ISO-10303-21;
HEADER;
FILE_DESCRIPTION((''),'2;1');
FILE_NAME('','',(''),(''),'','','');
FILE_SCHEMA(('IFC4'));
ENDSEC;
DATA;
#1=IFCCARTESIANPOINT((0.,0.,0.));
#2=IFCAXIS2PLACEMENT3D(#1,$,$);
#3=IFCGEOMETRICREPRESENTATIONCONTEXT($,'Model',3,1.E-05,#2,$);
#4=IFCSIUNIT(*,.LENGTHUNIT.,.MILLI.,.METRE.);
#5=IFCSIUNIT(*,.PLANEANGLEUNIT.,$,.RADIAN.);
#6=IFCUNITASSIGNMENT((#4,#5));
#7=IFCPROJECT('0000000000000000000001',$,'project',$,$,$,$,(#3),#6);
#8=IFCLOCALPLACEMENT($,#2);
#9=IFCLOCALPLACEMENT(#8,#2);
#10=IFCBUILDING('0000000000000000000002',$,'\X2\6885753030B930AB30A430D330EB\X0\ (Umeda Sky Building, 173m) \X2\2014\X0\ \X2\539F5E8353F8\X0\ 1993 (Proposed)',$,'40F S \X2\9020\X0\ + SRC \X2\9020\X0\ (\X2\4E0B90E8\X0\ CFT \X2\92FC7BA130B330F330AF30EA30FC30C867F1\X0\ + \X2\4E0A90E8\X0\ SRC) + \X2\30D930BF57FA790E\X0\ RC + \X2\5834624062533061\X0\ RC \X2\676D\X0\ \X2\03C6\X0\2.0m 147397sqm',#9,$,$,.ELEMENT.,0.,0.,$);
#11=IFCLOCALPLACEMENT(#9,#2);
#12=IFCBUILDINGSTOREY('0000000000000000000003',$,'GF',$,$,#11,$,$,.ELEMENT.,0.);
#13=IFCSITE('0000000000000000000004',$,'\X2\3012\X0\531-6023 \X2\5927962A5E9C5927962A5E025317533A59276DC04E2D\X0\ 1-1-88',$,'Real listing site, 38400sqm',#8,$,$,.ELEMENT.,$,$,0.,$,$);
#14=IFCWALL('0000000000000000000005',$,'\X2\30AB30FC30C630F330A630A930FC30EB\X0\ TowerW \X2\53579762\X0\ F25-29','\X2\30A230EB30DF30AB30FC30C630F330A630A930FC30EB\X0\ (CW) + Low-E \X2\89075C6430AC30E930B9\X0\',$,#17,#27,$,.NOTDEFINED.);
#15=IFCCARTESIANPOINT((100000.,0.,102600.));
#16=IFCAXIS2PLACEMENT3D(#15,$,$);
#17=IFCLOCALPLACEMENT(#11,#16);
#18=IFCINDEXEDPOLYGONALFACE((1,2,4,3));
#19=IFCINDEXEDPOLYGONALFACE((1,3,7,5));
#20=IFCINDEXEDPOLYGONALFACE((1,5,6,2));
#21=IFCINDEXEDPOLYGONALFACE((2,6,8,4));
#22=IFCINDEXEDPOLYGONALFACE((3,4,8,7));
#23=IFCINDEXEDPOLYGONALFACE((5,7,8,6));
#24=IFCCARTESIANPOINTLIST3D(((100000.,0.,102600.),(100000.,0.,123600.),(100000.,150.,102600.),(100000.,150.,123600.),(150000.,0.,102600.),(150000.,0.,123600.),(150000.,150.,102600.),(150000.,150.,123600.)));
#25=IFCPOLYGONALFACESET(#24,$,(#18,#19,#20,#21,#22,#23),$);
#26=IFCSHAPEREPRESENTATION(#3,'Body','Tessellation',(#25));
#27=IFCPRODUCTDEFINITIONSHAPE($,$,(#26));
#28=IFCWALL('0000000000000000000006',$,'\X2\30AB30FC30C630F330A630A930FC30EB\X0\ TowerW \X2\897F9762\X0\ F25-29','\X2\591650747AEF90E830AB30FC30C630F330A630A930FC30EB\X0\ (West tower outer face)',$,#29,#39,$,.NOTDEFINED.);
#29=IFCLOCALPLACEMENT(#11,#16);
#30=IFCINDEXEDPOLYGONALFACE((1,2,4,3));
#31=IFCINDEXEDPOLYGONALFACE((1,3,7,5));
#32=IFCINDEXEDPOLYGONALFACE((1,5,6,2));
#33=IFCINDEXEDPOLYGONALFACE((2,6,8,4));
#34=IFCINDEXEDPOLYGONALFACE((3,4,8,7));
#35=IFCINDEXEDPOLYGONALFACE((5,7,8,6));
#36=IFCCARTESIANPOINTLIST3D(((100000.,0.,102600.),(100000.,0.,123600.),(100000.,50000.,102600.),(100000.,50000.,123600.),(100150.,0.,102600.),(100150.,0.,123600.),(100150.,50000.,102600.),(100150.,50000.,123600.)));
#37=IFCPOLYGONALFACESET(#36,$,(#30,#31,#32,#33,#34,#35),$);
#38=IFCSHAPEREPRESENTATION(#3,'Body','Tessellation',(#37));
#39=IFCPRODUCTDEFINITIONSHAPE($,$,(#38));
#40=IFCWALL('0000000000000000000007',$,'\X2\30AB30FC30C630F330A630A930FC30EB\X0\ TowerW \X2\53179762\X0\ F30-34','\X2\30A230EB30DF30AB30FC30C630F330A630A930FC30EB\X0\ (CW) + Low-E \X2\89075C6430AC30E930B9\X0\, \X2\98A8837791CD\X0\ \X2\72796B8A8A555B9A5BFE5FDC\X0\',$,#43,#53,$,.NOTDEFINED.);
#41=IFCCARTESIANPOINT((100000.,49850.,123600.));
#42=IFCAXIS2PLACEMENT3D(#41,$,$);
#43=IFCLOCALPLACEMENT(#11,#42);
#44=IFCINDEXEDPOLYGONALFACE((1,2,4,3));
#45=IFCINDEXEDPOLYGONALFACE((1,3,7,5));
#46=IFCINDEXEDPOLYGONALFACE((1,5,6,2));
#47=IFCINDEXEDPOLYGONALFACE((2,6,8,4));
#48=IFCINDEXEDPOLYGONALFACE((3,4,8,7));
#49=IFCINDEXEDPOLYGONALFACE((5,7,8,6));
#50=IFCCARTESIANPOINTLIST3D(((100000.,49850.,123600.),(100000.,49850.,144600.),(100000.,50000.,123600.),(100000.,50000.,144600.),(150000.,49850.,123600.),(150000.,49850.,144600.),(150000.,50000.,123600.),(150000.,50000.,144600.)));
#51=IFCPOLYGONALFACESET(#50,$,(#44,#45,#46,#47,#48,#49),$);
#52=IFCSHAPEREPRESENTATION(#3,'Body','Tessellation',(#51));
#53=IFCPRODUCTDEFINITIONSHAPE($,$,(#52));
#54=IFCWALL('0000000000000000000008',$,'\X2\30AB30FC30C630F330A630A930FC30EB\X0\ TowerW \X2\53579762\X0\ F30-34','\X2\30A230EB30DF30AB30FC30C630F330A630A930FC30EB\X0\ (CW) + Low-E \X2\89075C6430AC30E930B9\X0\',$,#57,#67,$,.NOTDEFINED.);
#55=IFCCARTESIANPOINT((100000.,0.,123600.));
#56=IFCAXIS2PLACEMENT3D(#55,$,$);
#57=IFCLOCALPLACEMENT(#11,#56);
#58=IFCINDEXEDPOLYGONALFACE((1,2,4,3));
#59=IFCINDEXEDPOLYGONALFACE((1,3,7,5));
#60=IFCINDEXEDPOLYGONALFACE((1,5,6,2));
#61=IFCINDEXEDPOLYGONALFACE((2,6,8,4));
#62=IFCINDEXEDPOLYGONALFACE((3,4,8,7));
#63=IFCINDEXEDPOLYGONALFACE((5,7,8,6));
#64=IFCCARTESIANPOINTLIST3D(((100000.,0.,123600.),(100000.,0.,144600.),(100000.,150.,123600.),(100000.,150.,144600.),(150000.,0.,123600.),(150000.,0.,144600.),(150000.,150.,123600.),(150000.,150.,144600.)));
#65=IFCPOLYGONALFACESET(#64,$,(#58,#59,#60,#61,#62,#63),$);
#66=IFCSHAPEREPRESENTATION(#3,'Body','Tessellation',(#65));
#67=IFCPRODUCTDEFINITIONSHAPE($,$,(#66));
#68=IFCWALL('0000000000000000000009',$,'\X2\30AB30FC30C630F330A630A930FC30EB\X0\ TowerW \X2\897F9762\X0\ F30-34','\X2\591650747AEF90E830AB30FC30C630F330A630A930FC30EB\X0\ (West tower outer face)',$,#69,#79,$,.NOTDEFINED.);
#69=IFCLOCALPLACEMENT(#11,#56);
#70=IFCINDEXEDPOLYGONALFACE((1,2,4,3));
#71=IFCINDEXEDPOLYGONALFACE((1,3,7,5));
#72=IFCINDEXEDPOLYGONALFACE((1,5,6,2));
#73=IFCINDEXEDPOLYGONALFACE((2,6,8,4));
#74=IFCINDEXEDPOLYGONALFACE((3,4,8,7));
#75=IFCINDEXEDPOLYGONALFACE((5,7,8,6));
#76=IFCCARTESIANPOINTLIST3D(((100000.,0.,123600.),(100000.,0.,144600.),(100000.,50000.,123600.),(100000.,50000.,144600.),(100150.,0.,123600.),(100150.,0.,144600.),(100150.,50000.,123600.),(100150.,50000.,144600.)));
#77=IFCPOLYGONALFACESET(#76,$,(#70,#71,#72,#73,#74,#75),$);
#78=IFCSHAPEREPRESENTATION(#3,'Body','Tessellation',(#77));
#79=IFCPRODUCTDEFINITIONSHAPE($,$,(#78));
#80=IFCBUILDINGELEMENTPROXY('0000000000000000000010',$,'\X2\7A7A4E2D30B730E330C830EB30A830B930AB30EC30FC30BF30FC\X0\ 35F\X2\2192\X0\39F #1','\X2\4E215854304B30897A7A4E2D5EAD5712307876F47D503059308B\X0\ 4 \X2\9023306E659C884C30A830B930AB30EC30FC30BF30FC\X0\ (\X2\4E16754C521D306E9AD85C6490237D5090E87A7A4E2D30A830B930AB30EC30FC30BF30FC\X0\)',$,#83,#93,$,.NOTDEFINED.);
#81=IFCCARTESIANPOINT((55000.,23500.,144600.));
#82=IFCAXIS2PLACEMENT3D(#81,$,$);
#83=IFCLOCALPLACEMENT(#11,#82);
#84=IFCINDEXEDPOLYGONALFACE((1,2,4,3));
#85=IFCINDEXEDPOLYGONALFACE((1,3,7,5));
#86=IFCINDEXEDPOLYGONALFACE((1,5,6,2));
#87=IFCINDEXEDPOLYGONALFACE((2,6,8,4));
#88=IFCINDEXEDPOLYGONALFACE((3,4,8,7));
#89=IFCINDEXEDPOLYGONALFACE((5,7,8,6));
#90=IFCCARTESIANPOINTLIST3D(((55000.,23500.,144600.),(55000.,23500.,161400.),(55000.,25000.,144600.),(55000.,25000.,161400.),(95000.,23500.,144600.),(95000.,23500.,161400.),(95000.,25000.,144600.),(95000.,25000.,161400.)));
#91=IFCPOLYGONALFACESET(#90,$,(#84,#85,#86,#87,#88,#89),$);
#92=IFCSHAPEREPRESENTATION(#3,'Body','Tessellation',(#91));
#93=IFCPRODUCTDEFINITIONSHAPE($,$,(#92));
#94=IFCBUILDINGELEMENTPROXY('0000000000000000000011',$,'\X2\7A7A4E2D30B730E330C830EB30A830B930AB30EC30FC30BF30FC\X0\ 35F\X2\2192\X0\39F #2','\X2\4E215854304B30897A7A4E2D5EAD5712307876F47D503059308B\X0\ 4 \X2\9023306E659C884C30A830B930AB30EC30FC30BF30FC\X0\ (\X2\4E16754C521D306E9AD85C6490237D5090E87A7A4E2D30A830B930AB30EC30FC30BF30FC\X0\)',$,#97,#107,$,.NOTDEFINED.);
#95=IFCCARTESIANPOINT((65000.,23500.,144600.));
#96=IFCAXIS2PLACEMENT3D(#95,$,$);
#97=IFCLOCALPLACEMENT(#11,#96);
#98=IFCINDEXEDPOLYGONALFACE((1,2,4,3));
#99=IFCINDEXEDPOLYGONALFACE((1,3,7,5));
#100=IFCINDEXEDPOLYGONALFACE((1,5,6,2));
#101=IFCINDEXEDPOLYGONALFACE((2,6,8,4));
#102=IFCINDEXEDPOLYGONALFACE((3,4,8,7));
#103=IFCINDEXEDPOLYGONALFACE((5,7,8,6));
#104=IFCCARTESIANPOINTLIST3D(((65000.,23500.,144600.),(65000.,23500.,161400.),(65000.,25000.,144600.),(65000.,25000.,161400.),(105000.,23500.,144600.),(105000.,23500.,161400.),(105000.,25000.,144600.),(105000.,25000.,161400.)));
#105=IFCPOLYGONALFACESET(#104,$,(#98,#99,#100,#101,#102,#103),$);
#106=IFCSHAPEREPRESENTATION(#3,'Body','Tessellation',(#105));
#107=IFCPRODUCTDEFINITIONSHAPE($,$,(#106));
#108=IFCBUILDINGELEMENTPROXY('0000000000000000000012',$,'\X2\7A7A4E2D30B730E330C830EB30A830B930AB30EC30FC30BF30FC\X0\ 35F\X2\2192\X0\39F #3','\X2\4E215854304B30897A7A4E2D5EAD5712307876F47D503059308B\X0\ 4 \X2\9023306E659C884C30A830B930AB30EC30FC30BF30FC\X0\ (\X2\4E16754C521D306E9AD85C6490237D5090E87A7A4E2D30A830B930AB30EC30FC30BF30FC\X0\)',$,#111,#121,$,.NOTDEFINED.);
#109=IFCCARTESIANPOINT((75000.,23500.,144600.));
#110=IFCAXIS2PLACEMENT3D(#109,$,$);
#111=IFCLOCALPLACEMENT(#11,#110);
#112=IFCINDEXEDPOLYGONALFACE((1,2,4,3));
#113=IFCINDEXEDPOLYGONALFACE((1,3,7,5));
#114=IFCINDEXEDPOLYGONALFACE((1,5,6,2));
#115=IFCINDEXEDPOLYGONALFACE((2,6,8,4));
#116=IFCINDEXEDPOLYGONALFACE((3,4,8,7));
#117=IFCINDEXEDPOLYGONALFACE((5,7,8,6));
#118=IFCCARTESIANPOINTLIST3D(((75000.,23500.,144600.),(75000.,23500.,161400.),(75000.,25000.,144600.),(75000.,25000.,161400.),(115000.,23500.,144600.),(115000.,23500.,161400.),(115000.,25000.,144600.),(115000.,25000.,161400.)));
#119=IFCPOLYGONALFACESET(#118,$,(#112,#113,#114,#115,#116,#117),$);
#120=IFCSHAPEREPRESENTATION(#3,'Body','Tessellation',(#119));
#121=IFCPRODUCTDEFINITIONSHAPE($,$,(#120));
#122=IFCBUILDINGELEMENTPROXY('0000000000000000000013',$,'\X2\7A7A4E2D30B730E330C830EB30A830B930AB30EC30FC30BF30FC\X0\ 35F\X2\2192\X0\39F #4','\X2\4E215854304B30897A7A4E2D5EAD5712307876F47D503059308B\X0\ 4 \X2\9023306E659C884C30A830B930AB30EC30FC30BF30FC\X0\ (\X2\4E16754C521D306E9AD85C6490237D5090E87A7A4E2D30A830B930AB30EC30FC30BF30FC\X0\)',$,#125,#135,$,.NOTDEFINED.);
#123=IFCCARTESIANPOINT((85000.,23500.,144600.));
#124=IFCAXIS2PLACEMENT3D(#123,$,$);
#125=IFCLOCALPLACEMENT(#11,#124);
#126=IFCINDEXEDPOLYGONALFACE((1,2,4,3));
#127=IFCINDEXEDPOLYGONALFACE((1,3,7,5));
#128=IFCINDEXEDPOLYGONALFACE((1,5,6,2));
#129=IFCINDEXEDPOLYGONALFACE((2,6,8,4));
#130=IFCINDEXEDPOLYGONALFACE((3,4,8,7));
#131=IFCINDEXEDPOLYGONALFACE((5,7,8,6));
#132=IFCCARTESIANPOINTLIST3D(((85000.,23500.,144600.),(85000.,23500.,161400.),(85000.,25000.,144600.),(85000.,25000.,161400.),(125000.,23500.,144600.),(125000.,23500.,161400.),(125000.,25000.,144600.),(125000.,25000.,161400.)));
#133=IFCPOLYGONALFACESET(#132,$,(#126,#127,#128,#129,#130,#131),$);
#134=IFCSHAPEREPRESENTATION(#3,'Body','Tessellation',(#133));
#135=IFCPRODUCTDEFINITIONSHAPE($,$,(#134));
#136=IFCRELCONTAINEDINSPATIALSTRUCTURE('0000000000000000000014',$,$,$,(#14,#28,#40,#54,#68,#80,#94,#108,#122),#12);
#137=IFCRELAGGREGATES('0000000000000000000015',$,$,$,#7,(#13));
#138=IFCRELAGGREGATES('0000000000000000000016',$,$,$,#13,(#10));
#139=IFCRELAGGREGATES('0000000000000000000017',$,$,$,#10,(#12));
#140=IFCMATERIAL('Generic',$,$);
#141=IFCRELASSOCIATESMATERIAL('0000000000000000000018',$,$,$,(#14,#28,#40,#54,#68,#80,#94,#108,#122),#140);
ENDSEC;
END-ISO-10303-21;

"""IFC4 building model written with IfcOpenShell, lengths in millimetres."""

from ifc_helpers import new_model, si_unit, frame, frame_2d, origin, place, context, project, spatial, rectangle, extrude, material, element, save


model = new_model("IFC4")

# Units and contexts
model_context = context("Model", 3, precision=1e-05, world=origin())
ifc_project = project(units=[si_unit("LENGTHUNIT", "METRE", prefix="MILLI"), si_unit("PLANEANGLEUNIT", "RADIAN")], contexts=[model_context])

# Site, building, storey
site_placement = place(None, origin())
site = spatial("IfcSite", under=ifc_project, at=site_placement, Name="〒531-6023 大阪府大阪市北区大淀中 1-1-88", ObjectType="Real listing site, 38400sqm", CompositionType="ELEMENT", RefElevation=0.0)
building_placement = place(site_placement, origin())
building = spatial("IfcBuilding", under=site, at=building_placement, Name="梅田スカイビル (Umeda Sky Building, 173m) — 原広司 1993 (Proposed)", ObjectType="40F S 造 + SRC 造 (下部 CFT 鋼管コンクリート柱 + 上部 SRC) + ベタ基礎 RC + 場所打ち RC 杭 φ2.0m 147397sqm", CompositionType="ELEMENT", ElevationOfRefHeight=0.0, ElevationOfTerrain=0.0)
storey_placement = place(building_placement, origin())
storey = spatial("IfcBuildingStorey", under=building, at=storey_placement, Name="GF", CompositionType="ELEMENT", Elevation=0.0)

# Shared definitions
ifc_material_1 = material(Name="Generic")

# Walls
wall_1_placement = place(storey_placement, frame((100000.0, 0.0, 102600.0)))
element("IfcWall", 1, at=wall_1_placement, inside=storey, material=ifc_material_1, Name="カーテンウォール TowerW 南面 F25-29", Description="アルミカーテンウォール (CW) + Low-E 複層ガラス", PredefinedType="NOTDEFINED", context=model_context, shape_type="SweptSolid", body=[
    extrude(rectangle(XDim=50000.0, YDim=150.0, at=frame_2d((25000.0, 75.0))), frame((100000.0, 0.0, 102600.0)), (0.0, 0.0, 1.0), 21000.0),
])
wall_2_placement = place(storey_placement, frame((100000.0, 0.0, 102600.0)))
element("IfcWall", 2, at=wall_2_placement, inside=storey, material=ifc_material_1, Name="カーテンウォール TowerW 西面 F25-29", Description="外側端部カーテンウォール (West tower outer face)", PredefinedType="NOTDEFINED", context=model_context, shape_type="SweptSolid", body=[
    extrude(rectangle(XDim=150.0, YDim=50000.0, at=frame_2d((75.0, 25000.0))), frame((100000.0, 0.0, 102600.0)), (0.0, 0.0, 1.0), 21000.0),
])
wall_3_placement = place(storey_placement, frame((100000.0, 49850.0, 123600.0)))
element("IfcWall", 3, at=wall_3_placement, inside=storey, material=ifc_material_1, Name="カーテンウォール TowerW 北面 F30-34", Description="アルミカーテンウォール (CW) + Low-E 複層ガラス, 風荷重 特殊評定対応", PredefinedType="NOTDEFINED", context=model_context, shape_type="SweptSolid", body=[
    extrude(rectangle(XDim=50000.0, YDim=150.0, at=frame_2d((25000.0, 75.0))), frame((100000.0, 49850.0, 123600.0)), (0.0, 0.0, 1.0), 21000.0),
])
wall_4_placement = place(storey_placement, frame((100000.0, 0.0, 123600.0)))
element("IfcWall", 4, at=wall_4_placement, inside=storey, material=ifc_material_1, Name="カーテンウォール TowerW 南面 F30-34", Description="アルミカーテンウォール (CW) + Low-E 複層ガラス", PredefinedType="NOTDEFINED", context=model_context, shape_type="SweptSolid", body=[
    extrude(rectangle(XDim=50000.0, YDim=150.0, at=frame_2d((25000.0, 75.0))), frame((100000.0, 0.0, 123600.0)), (0.0, 0.0, 1.0), 21000.0),
])
wall_5_placement = place(storey_placement, frame((100000.0, 0.0, 123600.0)))
element("IfcWall", 5, at=wall_5_placement, inside=storey, material=ifc_material_1, Name="カーテンウォール TowerW 西面 F30-34", Description="外側端部カーテンウォール (West tower outer face)", PredefinedType="NOTDEFINED", context=model_context, shape_type="SweptSolid", body=[
    extrude(rectangle(XDim=150.0, YDim=50000.0, at=frame_2d((75.0, 25000.0))), frame((100000.0, 0.0, 123600.0)), (0.0, 0.0, 1.0), 21000.0),
])

# Building element proxies
proxy_1_placement = place(storey_placement, frame((55000.0, 23500.0, 144600.0)))
element("IfcBuildingElementProxy", 6, at=proxy_1_placement, inside=storey, material=ifc_material_1, Name="空中シャトルエスカレーター 35F→39F #1", Description="両塔から空中庭園へ直結する 4 連の斜行エスカレーター (世界初の高層連結部空中エスカレーター)", PredefinedType="NOTDEFINED", context=model_context, shape_type="SweptSolid", body=[
    extrude(rectangle(XDim=40000.0, YDim=1500.0, at=frame_2d((20000.0, 750.0))), frame((55000.0, 23500.0, 144600.0)), (0.0, 0.0, 1.0), 16800.0),
])
proxy_2_placement = place(storey_placement, frame((65000.0, 23500.0, 144600.0)))
element("IfcBuildingElementProxy", 7, at=proxy_2_placement, inside=storey, material=ifc_material_1, Name="空中シャトルエスカレーター 35F→39F #2", Description="両塔から空中庭園へ直結する 4 連の斜行エスカレーター (世界初の高層連結部空中エスカレーター)", PredefinedType="NOTDEFINED", context=model_context, shape_type="SweptSolid", body=[
    extrude(rectangle(XDim=40000.0, YDim=1500.0, at=frame_2d((20000.0, 750.0))), frame((65000.0, 23500.0, 144600.0)), (0.0, 0.0, 1.0), 16800.0),
])
proxy_3_placement = place(storey_placement, frame((75000.0, 23500.0, 144600.0)))
element("IfcBuildingElementProxy", 8, at=proxy_3_placement, inside=storey, material=ifc_material_1, Name="空中シャトルエスカレーター 35F→39F #3", Description="両塔から空中庭園へ直結する 4 連の斜行エスカレーター (世界初の高層連結部空中エスカレーター)", PredefinedType="NOTDEFINED", context=model_context, shape_type="SweptSolid", body=[
    extrude(rectangle(XDim=40000.0, YDim=1500.0, at=frame_2d((20000.0, 750.0))), frame((75000.0, 23500.0, 144600.0)), (0.0, 0.0, 1.0), 16800.0),
])
proxy_4_placement = place(storey_placement, frame((85000.0, 23500.0, 144600.0)))
element("IfcBuildingElementProxy", 9, at=proxy_4_placement, inside=storey, material=ifc_material_1, Name="空中シャトルエスカレーター 35F→39F #4", Description="両塔から空中庭園へ直結する 4 連の斜行エスカレーター (世界初の高層連結部空中エスカレーター)", PredefinedType="NOTDEFINED", context=model_context, shape_type="SweptSolid", body=[
    extrude(rectangle(XDim=40000.0, YDim=1500.0, at=frame_2d((20000.0, 750.0))), frame((85000.0, 23500.0, 144600.0)), (0.0, 0.0, 1.0), 16800.0),
])

save(model, "model.ifc")
